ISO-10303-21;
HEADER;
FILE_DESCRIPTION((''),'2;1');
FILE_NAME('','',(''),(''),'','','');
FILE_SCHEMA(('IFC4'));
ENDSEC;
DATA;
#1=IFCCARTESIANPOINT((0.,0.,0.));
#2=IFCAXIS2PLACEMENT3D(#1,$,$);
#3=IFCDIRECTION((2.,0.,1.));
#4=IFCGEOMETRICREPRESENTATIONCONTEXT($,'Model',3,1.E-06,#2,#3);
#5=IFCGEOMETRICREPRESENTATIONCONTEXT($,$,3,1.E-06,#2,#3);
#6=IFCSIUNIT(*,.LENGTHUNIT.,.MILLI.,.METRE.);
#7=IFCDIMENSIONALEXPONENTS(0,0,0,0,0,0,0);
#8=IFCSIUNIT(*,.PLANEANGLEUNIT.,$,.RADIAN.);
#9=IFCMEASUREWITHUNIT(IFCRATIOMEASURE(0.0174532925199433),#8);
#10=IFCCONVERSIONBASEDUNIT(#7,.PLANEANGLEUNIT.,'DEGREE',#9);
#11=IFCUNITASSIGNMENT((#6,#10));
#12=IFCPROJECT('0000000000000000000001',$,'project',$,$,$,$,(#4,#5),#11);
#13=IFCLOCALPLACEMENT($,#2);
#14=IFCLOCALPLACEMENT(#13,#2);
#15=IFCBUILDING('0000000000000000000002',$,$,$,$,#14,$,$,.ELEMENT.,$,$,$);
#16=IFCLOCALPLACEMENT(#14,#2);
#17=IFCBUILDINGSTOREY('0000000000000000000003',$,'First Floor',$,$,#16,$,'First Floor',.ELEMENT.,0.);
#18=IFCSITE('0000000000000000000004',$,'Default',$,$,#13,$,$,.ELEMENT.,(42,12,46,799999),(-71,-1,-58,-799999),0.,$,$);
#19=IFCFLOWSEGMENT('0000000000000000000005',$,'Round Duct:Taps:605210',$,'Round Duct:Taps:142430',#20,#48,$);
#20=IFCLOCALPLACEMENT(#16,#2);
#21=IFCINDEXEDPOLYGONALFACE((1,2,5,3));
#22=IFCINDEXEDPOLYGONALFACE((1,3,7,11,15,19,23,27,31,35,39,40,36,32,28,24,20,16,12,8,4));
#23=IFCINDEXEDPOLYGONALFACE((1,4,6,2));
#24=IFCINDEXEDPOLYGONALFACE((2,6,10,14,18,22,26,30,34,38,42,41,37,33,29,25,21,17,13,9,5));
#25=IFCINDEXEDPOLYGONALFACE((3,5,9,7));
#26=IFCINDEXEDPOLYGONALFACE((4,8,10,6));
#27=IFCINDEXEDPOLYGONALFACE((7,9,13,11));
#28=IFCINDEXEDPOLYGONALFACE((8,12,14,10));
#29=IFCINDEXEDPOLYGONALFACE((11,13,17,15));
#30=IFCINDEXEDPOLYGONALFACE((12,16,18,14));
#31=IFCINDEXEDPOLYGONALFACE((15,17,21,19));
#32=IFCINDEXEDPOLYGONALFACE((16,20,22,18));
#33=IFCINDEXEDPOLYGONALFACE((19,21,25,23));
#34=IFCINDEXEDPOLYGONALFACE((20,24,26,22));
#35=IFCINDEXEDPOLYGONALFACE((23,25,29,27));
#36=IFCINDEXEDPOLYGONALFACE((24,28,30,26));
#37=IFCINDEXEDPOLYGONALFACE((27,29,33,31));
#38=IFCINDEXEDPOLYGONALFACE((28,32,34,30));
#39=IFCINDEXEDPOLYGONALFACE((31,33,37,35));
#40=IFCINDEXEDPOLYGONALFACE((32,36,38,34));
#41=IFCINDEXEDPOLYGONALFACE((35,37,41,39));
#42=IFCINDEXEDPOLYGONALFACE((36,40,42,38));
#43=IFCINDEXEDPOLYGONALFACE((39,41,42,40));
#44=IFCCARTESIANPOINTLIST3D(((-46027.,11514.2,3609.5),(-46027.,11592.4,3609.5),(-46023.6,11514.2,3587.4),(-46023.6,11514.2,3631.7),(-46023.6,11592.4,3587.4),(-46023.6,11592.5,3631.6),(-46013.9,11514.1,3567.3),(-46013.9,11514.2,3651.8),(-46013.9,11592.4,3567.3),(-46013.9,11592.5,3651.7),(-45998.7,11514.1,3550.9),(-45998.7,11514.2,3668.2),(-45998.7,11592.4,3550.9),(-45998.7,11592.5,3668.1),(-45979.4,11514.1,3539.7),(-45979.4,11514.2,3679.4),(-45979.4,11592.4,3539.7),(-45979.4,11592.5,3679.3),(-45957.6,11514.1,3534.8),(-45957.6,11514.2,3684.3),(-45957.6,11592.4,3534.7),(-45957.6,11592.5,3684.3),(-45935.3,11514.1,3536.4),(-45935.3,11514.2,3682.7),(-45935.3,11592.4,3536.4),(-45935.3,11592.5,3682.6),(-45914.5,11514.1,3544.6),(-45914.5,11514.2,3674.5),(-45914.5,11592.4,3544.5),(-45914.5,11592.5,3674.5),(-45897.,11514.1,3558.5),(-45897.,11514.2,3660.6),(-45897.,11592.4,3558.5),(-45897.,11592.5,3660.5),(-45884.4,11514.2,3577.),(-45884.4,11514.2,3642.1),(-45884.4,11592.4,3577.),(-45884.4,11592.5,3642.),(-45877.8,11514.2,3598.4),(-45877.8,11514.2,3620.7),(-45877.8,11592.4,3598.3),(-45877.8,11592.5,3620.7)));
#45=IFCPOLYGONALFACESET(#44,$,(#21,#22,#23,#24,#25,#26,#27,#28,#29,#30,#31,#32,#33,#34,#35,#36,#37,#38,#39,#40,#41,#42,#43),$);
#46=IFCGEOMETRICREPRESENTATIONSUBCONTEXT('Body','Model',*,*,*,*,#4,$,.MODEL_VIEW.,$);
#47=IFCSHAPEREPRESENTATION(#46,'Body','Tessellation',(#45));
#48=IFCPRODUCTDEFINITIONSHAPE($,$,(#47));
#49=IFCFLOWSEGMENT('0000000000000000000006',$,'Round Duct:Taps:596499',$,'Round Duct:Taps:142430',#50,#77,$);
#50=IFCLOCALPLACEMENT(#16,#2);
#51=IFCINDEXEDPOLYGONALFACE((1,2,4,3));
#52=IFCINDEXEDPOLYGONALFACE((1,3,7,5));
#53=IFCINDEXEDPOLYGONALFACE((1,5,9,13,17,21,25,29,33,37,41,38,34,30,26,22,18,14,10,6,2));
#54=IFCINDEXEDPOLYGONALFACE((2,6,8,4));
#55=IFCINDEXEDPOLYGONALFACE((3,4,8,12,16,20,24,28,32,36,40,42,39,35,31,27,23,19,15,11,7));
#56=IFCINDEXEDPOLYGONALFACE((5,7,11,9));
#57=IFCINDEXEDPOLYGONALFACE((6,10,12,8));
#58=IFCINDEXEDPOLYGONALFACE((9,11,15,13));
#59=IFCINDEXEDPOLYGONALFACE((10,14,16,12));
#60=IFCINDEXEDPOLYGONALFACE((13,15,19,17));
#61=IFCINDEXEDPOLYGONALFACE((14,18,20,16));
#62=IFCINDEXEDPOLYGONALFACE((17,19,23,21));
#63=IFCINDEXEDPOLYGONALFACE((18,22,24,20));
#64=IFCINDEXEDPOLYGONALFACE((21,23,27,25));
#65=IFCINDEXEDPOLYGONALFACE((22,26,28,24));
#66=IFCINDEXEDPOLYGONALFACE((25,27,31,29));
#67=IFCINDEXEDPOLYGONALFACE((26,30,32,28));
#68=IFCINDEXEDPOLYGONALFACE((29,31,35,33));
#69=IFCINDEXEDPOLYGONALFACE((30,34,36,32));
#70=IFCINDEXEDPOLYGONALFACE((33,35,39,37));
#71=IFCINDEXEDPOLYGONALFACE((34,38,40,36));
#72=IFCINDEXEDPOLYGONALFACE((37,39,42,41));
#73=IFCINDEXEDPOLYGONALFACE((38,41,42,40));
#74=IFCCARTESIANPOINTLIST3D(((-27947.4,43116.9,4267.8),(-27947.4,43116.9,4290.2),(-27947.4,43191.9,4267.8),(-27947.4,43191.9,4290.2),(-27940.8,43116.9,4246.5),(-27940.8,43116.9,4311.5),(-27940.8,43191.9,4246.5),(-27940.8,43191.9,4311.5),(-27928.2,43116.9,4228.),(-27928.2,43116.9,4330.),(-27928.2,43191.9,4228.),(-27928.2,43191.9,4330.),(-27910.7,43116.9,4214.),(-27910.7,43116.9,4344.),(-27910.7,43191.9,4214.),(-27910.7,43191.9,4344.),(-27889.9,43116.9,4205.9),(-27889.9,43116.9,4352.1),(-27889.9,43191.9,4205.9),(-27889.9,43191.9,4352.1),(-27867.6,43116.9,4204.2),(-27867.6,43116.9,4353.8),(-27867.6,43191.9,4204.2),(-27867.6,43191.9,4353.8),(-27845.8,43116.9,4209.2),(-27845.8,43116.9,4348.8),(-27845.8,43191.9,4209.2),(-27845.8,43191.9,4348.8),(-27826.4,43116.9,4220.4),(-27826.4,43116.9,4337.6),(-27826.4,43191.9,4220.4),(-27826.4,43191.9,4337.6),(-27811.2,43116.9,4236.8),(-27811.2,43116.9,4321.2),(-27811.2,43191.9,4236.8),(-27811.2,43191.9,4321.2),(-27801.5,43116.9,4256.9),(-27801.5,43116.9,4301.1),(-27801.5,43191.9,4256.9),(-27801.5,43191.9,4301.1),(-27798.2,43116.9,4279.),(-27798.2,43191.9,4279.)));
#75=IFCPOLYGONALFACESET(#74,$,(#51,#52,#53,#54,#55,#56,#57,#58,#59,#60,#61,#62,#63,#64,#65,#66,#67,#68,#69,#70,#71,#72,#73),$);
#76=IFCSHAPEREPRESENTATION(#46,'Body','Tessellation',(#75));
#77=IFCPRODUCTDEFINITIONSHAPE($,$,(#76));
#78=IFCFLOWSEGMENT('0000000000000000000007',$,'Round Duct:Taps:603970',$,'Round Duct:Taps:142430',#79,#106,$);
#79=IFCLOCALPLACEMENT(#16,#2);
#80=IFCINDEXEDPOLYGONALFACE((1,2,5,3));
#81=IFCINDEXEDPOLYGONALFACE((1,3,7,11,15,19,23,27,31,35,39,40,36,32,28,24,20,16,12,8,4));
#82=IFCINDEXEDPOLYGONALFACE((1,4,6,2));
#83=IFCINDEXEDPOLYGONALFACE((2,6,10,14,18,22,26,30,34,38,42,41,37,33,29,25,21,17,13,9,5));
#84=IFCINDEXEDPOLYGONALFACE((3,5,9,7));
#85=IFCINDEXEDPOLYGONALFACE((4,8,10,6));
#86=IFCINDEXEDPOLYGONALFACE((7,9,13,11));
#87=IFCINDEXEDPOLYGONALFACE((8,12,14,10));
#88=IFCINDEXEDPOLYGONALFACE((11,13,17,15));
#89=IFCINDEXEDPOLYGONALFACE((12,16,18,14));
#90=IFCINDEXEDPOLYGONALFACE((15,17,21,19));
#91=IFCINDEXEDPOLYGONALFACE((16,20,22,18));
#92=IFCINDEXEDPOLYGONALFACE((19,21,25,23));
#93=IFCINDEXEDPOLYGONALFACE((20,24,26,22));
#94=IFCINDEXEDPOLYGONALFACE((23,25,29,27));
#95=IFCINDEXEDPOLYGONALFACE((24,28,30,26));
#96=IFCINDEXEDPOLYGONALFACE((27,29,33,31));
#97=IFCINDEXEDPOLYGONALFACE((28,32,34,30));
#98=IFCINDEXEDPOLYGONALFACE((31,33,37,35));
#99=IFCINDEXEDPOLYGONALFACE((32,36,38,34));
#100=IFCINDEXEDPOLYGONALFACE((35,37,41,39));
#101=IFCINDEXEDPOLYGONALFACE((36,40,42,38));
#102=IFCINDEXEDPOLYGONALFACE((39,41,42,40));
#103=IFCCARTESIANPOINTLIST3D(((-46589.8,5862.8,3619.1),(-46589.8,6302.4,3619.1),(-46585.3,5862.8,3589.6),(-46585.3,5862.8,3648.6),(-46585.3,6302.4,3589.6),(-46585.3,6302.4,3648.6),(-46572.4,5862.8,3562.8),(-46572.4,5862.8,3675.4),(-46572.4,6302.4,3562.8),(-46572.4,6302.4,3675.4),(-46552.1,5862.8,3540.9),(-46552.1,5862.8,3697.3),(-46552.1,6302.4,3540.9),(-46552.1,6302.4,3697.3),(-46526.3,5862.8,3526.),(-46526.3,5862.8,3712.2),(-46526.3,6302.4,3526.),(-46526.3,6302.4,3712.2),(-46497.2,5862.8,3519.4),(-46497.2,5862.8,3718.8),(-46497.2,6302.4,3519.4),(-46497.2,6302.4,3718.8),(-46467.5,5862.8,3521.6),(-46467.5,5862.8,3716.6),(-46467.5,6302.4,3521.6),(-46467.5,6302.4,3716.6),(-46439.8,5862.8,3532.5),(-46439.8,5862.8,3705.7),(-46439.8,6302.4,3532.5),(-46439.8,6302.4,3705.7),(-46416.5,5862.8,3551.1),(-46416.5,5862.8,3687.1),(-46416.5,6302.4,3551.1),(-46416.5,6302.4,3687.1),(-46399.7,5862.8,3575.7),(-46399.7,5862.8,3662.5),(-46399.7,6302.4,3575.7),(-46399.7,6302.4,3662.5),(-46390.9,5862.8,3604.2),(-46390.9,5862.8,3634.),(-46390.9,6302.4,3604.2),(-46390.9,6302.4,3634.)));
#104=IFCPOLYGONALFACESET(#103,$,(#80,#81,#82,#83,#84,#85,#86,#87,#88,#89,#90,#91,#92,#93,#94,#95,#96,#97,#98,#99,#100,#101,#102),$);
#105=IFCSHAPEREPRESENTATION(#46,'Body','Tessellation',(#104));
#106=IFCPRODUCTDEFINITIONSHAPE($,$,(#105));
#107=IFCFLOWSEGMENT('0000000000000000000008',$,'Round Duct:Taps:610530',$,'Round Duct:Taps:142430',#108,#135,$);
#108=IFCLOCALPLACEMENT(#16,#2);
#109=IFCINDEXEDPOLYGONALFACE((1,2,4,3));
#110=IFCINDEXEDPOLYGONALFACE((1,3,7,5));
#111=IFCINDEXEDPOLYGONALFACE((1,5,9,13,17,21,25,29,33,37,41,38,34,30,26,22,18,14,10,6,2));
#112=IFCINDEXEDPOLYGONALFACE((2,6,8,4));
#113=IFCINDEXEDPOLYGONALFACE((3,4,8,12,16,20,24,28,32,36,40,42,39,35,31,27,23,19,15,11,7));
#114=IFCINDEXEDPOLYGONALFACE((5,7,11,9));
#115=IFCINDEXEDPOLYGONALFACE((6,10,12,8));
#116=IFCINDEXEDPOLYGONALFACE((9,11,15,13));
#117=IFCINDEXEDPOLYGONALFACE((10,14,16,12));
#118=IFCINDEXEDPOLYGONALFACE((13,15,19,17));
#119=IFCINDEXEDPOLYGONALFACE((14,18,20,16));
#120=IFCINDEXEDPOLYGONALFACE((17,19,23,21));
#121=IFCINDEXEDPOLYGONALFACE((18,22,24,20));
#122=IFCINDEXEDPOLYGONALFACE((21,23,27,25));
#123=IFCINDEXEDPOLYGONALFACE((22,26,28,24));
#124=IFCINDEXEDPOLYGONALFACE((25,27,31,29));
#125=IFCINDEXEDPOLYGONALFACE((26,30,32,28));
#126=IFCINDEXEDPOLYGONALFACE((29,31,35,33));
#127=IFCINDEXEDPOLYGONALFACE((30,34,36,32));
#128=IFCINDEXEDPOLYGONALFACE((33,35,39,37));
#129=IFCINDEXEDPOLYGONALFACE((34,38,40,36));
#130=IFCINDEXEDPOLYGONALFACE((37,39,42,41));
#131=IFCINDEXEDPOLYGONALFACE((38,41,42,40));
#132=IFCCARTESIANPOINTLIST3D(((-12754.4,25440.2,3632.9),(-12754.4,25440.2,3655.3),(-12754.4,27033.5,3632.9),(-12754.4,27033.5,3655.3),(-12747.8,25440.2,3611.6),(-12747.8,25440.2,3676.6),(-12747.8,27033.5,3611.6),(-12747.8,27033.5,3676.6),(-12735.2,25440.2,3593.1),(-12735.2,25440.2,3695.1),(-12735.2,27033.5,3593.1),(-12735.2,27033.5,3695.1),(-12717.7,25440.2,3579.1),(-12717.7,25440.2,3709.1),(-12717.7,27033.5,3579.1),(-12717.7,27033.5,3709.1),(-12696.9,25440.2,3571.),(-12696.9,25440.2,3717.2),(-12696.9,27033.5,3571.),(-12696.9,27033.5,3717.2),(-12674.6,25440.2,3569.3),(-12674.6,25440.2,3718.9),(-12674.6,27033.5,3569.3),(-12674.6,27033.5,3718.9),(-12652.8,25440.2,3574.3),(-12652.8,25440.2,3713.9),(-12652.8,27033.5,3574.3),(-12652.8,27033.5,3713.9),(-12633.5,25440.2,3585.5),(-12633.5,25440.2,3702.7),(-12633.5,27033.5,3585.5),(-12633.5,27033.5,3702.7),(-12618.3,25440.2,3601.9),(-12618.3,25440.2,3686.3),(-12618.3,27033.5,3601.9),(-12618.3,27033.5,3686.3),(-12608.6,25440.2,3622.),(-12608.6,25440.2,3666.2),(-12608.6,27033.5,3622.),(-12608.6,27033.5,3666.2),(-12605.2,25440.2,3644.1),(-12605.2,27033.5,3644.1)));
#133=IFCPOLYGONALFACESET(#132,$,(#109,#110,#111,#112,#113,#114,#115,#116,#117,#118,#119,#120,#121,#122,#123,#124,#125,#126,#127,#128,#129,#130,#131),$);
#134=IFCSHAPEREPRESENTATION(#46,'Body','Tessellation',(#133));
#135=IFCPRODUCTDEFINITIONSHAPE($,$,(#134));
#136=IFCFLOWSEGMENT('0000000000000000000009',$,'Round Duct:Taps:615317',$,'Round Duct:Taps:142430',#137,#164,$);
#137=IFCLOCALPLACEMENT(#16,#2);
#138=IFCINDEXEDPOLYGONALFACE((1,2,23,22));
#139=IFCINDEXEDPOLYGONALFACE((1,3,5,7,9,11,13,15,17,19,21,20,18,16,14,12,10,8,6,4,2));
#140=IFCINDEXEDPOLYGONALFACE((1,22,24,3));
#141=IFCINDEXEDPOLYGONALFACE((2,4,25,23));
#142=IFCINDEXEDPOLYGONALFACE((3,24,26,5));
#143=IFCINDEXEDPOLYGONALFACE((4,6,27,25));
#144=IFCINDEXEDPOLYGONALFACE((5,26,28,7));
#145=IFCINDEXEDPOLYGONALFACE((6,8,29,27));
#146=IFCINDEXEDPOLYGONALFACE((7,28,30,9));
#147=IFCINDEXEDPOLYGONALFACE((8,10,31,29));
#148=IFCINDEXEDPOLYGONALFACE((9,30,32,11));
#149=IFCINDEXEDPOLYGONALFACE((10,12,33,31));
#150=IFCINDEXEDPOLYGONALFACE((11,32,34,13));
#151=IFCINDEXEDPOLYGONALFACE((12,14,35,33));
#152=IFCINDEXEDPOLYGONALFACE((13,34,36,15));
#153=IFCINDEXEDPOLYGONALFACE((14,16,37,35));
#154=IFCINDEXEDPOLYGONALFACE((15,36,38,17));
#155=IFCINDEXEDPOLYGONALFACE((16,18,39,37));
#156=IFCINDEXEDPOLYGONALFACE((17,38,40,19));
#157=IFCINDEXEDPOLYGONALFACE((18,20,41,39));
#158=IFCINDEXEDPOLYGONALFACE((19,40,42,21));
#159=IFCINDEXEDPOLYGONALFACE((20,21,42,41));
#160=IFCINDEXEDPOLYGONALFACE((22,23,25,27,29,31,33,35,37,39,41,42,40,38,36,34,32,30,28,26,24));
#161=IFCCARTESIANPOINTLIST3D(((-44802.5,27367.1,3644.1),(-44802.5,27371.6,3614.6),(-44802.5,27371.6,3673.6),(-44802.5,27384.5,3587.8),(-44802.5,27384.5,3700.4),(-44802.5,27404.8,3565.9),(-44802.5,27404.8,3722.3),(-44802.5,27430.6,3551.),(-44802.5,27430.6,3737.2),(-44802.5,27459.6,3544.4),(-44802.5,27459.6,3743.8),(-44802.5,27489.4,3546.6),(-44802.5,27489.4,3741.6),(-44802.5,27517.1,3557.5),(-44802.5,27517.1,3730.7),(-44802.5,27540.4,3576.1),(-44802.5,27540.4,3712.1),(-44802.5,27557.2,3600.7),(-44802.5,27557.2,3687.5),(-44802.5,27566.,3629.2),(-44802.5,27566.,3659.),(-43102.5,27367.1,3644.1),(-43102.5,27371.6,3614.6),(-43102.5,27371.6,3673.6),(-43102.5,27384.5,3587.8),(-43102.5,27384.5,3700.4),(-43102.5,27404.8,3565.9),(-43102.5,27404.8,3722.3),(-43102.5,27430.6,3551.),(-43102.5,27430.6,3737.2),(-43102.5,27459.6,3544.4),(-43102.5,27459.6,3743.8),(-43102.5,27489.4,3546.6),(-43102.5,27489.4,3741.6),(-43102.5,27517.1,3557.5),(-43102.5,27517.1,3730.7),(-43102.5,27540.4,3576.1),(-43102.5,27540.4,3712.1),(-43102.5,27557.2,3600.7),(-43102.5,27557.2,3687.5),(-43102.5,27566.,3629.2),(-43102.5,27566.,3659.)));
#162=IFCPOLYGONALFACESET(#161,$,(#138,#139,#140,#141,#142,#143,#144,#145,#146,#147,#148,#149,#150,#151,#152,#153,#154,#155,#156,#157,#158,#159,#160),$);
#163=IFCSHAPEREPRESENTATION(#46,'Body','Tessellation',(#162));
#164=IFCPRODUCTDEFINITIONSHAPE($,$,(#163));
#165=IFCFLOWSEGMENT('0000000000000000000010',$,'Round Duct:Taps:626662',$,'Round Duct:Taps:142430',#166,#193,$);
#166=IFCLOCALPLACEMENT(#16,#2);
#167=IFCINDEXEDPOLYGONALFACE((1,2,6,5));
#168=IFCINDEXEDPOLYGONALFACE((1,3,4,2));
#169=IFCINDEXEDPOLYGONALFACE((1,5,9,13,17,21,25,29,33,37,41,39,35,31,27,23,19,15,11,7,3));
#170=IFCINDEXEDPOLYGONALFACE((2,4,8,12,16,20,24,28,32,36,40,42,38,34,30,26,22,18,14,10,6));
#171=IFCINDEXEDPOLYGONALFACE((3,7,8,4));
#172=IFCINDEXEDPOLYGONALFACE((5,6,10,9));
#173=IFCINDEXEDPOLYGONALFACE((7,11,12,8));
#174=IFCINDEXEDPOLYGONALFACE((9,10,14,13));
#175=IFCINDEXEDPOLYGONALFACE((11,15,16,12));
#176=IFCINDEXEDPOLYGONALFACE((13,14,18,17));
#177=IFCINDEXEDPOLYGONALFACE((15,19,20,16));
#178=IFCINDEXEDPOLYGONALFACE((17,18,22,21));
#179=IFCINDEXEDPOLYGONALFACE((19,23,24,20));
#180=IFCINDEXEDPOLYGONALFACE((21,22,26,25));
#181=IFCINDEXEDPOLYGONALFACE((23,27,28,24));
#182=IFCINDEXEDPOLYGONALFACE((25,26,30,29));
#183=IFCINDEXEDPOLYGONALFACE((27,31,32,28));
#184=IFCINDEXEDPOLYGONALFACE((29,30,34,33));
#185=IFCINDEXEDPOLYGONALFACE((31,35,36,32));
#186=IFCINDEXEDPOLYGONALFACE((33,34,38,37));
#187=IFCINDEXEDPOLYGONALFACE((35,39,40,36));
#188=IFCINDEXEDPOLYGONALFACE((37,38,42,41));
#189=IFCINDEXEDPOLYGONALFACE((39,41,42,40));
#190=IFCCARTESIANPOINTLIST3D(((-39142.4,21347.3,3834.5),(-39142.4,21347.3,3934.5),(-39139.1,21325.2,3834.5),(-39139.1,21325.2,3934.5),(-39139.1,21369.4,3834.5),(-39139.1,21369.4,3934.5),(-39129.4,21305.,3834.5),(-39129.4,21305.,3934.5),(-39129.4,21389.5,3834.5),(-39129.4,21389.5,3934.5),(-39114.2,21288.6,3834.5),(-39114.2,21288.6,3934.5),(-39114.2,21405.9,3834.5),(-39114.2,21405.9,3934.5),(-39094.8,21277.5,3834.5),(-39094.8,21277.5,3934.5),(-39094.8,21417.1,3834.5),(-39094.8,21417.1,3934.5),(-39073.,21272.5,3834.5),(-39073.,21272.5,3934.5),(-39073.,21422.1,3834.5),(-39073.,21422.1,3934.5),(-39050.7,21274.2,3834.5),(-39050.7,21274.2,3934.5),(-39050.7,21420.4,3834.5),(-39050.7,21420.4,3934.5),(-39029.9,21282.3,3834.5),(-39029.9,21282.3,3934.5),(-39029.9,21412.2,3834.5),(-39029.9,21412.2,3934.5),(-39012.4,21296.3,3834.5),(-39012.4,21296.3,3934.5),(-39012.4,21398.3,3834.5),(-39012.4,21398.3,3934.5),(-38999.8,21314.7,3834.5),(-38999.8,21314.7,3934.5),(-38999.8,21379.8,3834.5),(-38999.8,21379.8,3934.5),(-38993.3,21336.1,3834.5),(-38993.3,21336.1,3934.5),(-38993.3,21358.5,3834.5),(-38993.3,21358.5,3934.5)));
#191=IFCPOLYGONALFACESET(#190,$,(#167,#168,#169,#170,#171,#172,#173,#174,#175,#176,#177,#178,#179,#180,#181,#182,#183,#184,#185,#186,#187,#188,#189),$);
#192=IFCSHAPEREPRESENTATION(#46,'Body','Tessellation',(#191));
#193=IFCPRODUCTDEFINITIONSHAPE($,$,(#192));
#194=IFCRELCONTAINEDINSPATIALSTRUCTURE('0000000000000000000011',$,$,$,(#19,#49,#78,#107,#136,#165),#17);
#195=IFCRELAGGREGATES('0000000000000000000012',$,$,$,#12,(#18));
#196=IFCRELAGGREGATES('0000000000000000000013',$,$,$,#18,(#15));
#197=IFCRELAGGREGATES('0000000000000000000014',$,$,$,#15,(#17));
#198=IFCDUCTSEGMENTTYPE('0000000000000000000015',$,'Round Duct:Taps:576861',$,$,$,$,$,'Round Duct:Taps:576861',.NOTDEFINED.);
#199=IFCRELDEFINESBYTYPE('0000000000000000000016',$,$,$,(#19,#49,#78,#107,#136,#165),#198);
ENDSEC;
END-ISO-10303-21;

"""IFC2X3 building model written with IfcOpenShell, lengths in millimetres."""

from ifc_helpers import new_model, entity, si_unit, converted_unit, direction, frame, frame_2d, origin, origin_2d_with_axis, place, context, subcontext, project, spatial, circle, extrude, type_object, element, save


model = new_model("IFC2X3")

# Units and contexts
model_context = context("Model", 3, precision=1e-06, world=origin(), true_north=direction((2.0, 0.0, 1.0)))
context_of_model = context(None, 3, precision=1e-06, world=origin(), true_north=direction((2.0, 0.0, 1.0)))
body_context = subcontext(model_context, "Body", "Model", "MODEL_VIEW")
ifc_project = project(units=[si_unit("LENGTHUNIT", "METRE", prefix="MILLI"), converted_unit("PLANEANGLEUNIT", "DEGREE", entity("IfcRatioMeasure", 0.0174532925199433), si_unit("PLANEANGLEUNIT", "RADIAN"), dimensions=[0, 0, 0, 0, 0, 0, 0])], contexts=[model_context, context_of_model])

# Site, building, storey
site_placement = place(None, origin())
site = spatial("IfcSite", under=ifc_project, at=site_placement, Name="Default", CompositionType="ELEMENT", RefLatitude=(42, 12, 46, 799999), RefLongitude=(-71, -1, -58, -799999), RefElevation=0.0)
building_placement = place(site_placement, origin())
building = spatial("IfcBuilding", under=site, at=building_placement, CompositionType="ELEMENT")
storey_placement = place(building_placement, origin())
storey = spatial("IfcBuildingStorey", under=building, at=storey_placement, Name="First Floor", LongName="First Floor", CompositionType="ELEMENT", Elevation=0.0)

# Flow segments
duct_segment_type_1 = type_object("IfcDuctSegmentType", Name="Round Duct:Taps:576861", ElementType="Round Duct:Taps:576861", PredefinedType="NOTDEFINED")
flow_segment_1_placement = place(storey_placement, origin())
element("IfcFlowSegment", 1, at=flow_segment_1_placement, inside=storey, type_object=duct_segment_type_1, Name="Round Duct:Taps:605210", ObjectType="Round Duct:Taps:142430", context=body_context, shape_type="SweptSolid", body=[
    extrude(circle(Radius=75.0, at=frame_2d((0.0, 0.0), x_axis=(1.0, 0.0))), frame((-45952.0, 11514.2, 3609.5), z_axis=(0.0, 1.0, -0.000639), x_axis=(-1.0, 0.0, 0.0)), (0.0, 0.0, 1.0), 78.3),
])
flow_segment_2_placement = place(storey_placement, origin())
element("IfcFlowSegment", 2, at=flow_segment_2_placement, inside=storey, type_object=duct_segment_type_1, Name="Round Duct:Taps:596499", ObjectType="Round Duct:Taps:142430", context=body_context, shape_type="SweptSolid", body=[
    extrude(circle(Radius=75.0, at=origin_2d_with_axis()), frame((-27873.2, 43116.9, 4279.0), z_axis=(0.0, 1.0, 0.0), x_axis=(1.0, 0.0, 0.0)), (0.0, 0.0, 1.0), 75.0),
])
flow_segment_3_placement = place(storey_placement, origin())
element("IfcFlowSegment", 3, at=flow_segment_3_placement, inside=storey, type_object=duct_segment_type_1, Name="Round Duct:Taps:603970", ObjectType="Round Duct:Taps:142430", context=body_context, shape_type="SweptSolid", body=[
    extrude(circle(Radius=100.0, at=origin_2d_with_axis()), frame((-46489.8, 5862.8, 3619.1), z_axis=(0.0, 1.0, 0.0), x_axis=(-1.0, 0.0, 0.0)), (0.0, 0.0, 1.0), 439.6),
])
flow_segment_4_placement = place(storey_placement, origin())
element("IfcFlowSegment", 4, at=flow_segment_4_placement, inside=storey, type_object=duct_segment_type_1, Name="Round Duct:Taps:610530", ObjectType="Round Duct:Taps:142430", context=body_context, shape_type="SweptSolid", body=[
    extrude(circle(Radius=75.0, at=frame_2d((0.0, 0.0), x_axis=(1.0, 0.0))), frame((-12680.2, 25440.2, 3644.1), z_axis=(0.0, 1.0, 0.0), x_axis=(1.0, 0.0, 0.0)), (0.0, 0.0, 1.0), 1593.2),
])
flow_segment_5_placement = place(storey_placement, origin())
element("IfcFlowSegment", 5, at=flow_segment_5_placement, inside=storey, type_object=duct_segment_type_1, Name="Round Duct:Taps:615317", ObjectType="Round Duct:Taps:142430", context=body_context, shape_type="SweptSolid", body=[
    extrude(circle(Radius=100.0, at=origin_2d_with_axis()), frame((-44802.5, 27467.1, 3644.1), z_axis=(1.0, 0.0, 0.0), x_axis=(0.0, -1.0, 0.0)), (0.0, 0.0, 1.0), 1700.0),
])
flow_segment_6_placement = place(storey_placement, origin())
element("IfcFlowSegment", 6, at=flow_segment_6_placement, inside=storey, type_object=duct_segment_type_1, Name="Round Duct:Taps:626662", ObjectType="Round Duct:Taps:142430", context=body_context, shape_type="SweptSolid", body=[
    extrude(circle(Radius=75.0, at=frame_2d((0.0, 0.0), x_axis=(1.0, 0.0))), frame((-39067.4, 21347.3, 3834.5), z_axis=(0.0, 0.0, 1.0), x_axis=(-1.0, 0.0, 0.0)), (0.0, 0.0, 1.0), 100.0),
])

save(model, "model.ifc")
